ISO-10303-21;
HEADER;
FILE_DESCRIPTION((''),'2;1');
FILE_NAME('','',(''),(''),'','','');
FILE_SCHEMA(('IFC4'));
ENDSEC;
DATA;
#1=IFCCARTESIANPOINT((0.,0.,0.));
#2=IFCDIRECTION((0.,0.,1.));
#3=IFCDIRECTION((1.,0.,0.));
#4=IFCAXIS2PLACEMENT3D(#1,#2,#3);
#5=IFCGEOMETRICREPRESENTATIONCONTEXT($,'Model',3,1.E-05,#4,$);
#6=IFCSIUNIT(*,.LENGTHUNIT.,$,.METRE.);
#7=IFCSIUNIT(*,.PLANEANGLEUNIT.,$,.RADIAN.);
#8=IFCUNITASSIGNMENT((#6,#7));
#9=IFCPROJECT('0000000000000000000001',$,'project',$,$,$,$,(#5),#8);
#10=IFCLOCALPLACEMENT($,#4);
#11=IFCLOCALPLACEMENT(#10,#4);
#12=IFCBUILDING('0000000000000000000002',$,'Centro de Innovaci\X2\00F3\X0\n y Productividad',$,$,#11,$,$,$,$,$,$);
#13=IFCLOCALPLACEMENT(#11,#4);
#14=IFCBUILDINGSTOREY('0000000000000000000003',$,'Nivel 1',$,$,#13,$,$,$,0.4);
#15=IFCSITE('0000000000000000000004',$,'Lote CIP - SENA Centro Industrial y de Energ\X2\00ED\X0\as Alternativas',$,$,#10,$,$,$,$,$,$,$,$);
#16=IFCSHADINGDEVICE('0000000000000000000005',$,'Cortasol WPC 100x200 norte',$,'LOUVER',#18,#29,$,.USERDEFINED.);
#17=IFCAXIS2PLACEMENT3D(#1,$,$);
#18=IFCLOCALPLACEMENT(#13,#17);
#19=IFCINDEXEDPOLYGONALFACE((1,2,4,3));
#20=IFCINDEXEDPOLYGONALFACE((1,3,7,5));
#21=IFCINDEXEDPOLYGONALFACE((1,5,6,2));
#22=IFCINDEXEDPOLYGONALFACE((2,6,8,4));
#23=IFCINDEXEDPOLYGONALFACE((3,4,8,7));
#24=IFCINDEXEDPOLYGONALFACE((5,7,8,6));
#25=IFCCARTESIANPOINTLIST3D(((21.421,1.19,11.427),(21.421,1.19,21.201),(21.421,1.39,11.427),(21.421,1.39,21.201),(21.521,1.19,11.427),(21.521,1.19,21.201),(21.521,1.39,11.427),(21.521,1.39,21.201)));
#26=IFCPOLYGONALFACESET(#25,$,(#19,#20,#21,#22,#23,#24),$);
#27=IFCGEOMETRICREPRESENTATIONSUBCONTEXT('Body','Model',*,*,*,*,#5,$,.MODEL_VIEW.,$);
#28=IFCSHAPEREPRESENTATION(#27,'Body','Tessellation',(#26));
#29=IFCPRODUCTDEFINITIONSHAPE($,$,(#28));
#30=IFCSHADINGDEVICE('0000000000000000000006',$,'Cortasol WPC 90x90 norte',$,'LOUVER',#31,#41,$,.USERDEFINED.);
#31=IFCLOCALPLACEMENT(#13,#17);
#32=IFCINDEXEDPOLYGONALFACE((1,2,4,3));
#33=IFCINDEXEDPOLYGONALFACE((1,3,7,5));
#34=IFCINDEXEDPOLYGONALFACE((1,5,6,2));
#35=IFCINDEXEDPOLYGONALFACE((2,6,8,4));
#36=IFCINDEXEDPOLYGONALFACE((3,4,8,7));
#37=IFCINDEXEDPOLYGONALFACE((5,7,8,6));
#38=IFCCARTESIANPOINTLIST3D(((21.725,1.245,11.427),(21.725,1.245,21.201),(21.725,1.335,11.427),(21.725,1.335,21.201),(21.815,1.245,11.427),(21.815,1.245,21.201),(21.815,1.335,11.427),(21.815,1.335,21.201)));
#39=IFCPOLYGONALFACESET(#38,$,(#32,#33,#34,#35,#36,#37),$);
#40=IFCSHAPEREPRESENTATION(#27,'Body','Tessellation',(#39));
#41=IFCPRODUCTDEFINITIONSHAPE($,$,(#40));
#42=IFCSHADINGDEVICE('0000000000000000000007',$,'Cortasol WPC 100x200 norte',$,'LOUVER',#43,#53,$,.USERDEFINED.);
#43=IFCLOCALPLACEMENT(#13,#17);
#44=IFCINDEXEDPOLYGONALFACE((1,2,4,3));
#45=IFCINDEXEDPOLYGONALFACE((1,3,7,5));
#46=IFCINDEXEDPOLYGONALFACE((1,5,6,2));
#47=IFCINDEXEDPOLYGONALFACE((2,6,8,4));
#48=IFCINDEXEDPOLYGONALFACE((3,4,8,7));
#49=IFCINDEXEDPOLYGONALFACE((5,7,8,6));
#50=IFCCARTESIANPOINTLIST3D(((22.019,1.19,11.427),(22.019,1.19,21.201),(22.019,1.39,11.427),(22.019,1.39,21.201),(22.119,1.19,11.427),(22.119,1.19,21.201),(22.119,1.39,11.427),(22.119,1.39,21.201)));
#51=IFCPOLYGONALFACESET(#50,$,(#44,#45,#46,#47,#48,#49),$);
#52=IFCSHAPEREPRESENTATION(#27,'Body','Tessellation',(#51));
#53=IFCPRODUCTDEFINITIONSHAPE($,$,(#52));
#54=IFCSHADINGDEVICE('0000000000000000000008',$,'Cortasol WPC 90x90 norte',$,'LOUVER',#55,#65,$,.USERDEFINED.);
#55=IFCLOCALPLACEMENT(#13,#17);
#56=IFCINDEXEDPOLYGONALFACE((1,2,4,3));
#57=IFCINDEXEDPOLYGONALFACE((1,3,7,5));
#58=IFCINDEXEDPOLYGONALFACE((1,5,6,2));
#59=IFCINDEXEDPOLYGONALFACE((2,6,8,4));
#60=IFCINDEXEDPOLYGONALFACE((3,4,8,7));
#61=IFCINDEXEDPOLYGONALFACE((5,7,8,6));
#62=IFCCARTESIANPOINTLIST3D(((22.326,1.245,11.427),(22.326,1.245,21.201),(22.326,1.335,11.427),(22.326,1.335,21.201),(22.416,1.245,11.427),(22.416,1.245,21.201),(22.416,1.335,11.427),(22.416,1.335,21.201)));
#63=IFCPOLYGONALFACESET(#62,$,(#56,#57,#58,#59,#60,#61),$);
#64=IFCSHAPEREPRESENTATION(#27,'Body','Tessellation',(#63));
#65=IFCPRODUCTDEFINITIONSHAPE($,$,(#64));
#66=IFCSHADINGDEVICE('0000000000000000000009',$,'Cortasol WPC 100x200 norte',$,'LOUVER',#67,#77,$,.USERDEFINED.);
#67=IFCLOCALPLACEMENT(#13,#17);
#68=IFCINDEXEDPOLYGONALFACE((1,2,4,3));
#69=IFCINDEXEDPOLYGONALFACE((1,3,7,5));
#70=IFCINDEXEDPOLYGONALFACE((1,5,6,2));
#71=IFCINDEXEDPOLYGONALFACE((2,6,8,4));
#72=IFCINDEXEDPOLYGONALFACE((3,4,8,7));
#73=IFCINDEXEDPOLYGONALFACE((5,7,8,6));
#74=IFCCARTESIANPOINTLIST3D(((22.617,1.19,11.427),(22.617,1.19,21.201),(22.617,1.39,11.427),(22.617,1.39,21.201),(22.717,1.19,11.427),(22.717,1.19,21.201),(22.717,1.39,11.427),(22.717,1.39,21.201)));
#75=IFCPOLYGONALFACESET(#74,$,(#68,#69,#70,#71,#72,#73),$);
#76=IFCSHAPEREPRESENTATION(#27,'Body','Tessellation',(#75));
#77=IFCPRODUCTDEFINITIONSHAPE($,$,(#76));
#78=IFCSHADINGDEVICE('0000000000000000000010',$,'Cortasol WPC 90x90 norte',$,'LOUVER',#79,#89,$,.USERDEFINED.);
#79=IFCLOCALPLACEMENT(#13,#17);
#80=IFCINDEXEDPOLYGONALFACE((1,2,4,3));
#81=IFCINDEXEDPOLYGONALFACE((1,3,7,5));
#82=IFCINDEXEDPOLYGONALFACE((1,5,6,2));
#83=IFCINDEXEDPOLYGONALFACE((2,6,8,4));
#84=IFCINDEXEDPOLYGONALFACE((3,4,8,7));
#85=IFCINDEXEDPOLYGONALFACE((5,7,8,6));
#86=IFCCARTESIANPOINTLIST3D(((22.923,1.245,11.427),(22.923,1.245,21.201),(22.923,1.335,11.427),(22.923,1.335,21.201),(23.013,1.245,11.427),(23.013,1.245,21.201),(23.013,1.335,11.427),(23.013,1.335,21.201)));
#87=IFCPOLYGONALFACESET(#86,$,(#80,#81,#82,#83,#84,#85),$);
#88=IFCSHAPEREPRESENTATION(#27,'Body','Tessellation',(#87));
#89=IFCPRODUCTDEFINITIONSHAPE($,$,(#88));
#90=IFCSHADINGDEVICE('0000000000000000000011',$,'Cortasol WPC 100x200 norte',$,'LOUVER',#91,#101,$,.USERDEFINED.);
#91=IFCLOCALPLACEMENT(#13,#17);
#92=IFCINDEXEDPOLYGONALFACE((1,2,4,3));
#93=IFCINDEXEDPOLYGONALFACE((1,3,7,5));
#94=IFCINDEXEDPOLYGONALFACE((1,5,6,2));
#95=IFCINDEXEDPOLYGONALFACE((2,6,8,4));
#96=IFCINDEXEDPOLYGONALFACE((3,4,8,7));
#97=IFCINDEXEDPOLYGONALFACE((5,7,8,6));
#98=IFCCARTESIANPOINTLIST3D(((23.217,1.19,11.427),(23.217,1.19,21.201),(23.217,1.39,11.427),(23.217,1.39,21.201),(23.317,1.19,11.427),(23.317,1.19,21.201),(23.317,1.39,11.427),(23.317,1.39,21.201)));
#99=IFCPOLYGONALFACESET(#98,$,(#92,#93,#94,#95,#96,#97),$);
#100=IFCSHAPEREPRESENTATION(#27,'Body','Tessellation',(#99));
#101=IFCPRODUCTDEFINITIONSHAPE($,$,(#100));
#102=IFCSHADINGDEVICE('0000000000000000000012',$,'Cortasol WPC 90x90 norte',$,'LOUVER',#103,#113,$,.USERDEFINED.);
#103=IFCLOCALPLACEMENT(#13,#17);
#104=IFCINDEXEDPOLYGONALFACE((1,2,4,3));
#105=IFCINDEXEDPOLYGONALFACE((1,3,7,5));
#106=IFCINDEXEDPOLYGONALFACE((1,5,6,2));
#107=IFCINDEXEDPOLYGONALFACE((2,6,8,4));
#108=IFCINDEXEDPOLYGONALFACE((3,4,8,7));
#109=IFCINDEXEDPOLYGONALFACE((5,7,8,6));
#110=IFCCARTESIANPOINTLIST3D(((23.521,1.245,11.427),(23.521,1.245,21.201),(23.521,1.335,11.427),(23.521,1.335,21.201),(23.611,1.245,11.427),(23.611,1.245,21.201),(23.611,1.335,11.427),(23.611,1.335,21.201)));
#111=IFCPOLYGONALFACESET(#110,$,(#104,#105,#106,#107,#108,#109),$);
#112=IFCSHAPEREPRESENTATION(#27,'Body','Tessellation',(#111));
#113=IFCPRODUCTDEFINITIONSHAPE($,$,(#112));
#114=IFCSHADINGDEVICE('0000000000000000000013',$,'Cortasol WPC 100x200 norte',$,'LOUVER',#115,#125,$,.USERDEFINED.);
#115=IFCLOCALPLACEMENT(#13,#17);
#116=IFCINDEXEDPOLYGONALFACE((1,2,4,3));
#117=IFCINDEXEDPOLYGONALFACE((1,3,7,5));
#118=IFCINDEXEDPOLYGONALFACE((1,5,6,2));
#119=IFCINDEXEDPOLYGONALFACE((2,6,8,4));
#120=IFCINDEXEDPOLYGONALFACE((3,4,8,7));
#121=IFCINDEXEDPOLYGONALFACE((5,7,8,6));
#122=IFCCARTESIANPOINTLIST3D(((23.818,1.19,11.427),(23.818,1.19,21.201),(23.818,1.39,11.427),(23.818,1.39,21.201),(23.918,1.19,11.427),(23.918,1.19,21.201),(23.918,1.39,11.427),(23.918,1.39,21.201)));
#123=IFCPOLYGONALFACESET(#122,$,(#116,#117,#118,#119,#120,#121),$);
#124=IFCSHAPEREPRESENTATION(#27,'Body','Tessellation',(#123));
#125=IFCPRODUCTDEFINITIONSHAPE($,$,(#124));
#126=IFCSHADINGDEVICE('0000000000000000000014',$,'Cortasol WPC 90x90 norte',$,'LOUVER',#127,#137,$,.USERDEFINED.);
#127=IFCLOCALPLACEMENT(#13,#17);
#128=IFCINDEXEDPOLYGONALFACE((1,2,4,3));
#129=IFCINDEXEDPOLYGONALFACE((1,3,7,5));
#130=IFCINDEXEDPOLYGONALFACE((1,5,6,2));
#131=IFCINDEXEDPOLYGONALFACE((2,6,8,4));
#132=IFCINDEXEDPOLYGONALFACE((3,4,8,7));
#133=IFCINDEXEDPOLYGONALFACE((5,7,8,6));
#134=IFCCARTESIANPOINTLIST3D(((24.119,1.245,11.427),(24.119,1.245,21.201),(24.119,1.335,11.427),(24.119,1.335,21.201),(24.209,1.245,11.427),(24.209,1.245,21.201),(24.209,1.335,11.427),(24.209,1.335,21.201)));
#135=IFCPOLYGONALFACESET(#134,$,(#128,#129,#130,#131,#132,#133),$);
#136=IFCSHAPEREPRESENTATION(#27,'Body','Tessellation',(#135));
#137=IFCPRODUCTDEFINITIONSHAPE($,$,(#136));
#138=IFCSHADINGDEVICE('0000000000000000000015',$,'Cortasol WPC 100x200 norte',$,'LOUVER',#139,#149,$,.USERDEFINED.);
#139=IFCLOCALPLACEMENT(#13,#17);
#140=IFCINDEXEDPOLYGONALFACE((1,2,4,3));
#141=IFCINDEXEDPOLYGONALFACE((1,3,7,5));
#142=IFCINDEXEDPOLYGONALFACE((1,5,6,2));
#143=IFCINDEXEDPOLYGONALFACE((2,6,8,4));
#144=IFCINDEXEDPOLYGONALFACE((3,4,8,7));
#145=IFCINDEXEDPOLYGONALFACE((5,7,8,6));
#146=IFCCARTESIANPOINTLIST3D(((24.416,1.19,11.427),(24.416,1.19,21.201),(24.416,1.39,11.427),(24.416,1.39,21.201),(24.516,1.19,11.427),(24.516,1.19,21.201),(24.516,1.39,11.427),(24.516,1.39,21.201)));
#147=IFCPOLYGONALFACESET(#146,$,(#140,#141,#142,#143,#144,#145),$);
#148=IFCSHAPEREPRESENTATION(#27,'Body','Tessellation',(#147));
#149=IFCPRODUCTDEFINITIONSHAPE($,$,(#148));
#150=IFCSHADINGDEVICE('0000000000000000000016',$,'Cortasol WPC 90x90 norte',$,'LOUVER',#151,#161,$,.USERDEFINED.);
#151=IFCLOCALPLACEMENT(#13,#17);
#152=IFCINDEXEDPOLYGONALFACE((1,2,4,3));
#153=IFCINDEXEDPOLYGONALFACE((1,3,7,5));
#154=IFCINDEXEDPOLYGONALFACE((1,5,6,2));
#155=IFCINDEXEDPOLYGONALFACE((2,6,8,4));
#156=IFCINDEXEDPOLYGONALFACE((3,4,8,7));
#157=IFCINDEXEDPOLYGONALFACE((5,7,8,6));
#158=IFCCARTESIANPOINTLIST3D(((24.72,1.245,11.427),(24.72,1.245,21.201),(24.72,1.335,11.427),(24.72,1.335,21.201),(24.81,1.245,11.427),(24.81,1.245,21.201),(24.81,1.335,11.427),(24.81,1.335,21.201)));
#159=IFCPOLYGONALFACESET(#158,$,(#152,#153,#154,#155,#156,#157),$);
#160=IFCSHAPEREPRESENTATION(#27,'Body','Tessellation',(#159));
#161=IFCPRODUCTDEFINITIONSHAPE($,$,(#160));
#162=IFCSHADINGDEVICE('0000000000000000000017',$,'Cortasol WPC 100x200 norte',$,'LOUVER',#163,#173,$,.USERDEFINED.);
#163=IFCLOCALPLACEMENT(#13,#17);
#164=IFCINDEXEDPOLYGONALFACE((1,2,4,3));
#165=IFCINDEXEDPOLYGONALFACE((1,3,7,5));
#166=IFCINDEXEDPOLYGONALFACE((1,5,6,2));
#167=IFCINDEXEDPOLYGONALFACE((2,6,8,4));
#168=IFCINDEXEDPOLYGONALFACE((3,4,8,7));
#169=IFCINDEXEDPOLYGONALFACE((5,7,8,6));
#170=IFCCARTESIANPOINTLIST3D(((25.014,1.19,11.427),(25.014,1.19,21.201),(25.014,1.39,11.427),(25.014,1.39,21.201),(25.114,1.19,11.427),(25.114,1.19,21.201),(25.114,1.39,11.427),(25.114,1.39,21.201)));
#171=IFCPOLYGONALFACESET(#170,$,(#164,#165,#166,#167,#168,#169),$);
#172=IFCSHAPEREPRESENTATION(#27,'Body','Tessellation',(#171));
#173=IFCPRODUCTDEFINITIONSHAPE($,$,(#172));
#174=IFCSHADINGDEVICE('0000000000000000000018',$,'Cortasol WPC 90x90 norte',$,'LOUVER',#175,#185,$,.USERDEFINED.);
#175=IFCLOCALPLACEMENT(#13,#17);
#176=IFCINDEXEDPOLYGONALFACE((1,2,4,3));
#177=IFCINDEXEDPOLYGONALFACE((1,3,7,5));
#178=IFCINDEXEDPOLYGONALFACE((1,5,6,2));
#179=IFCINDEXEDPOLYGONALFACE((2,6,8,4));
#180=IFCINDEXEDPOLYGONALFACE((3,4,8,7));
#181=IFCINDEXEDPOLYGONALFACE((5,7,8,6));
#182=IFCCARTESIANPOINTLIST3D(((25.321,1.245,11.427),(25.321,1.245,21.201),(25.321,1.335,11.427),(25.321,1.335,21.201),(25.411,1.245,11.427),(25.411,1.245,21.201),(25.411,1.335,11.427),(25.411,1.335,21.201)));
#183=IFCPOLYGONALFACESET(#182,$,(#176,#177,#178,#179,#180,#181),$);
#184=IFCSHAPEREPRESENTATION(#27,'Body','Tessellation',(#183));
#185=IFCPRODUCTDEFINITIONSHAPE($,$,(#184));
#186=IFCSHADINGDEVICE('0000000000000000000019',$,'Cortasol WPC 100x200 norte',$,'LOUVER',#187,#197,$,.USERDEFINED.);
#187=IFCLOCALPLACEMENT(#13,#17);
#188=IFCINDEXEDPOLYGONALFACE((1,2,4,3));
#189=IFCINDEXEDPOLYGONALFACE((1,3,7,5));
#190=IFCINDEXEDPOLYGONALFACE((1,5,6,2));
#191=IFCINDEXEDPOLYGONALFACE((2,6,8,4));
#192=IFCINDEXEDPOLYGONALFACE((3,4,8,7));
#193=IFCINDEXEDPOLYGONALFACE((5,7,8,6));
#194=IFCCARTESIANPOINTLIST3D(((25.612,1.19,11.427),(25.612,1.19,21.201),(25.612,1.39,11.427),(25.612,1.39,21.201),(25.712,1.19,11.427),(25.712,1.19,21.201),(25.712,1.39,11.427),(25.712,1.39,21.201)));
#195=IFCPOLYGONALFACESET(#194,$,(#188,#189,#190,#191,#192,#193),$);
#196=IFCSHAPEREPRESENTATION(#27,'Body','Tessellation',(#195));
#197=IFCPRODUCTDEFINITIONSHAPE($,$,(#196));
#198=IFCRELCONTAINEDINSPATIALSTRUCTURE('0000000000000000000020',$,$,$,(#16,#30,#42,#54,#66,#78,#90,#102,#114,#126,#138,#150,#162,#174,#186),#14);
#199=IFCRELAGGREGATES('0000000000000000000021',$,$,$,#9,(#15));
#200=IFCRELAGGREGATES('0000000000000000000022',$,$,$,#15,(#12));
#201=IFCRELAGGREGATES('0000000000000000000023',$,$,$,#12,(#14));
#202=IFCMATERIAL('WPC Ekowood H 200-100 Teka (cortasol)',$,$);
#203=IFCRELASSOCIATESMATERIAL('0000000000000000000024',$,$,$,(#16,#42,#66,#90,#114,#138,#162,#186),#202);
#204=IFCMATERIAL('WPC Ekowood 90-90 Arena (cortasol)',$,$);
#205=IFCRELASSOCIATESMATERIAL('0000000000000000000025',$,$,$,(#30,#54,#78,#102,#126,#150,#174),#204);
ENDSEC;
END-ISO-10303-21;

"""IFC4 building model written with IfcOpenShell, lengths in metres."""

from ifc_helpers import new_model, si_unit, frame, origin_with_axes, place, context, subcontext, project, spatial, polyline, outline, extrude, material, element, save


model = new_model("IFC4")

# Units and contexts
model_context = context("Model", 3, precision=1e-05, world=origin_with_axes())
body_context = subcontext(model_context, "Body", "Model", "MODEL_VIEW")
ifc_project = project(units=[si_unit("LENGTHUNIT", "METRE"), si_unit("PLANEANGLEUNIT", "RADIAN")], contexts=[model_context])

# Site, building, storey
site_placement = place(None, origin_with_axes())
site = spatial("IfcSite", under=ifc_project, at=site_placement, Name="Lote CIP - SENA Centro Industrial y de Energías Alternativas")
building_placement = place(site_placement, origin_with_axes())
building = spatial("IfcBuilding", under=site, at=building_placement, Name="Centro de Innovación y Productividad")
storey_placement = place(building_placement, origin_with_axes())
storey = spatial("IfcBuildingStorey", under=building, at=storey_placement, Name="Nivel 1", Elevation=0.4)

# Shading devices
ifc_material_1 = material(Name="WPC Ekowood H 200-100 Teka (cortasol)")
shading_device_1_placement = place(storey_placement, origin_with_axes())
element("IfcShadingDevice", 1, at=shading_device_1_placement, inside=storey, material=ifc_material_1, Name="Cortasol WPC 100x200 norte", ObjectType="LOUVER", PredefinedType="USERDEFINED", context=body_context, shape_type="SweptSolid", body=[
    extrude(outline(polyline([(21.421, 1.19), (21.421, 1.39), (21.521, 1.39), (21.521, 1.19), (21.421, 1.19)])), frame((0.0, 0.0, 11.427)), (0.0, 0.0, 1.0), 9.774),
])
ifc_material_2 = material(Name="WPC Ekowood 90-90 Arena (cortasol)")
shading_device_2_placement = place(storey_placement, origin_with_axes())
element("IfcShadingDevice", 2, at=shading_device_2_placement, inside=storey, material=ifc_material_2, Name="Cortasol WPC 90x90 norte", ObjectType="LOUVER", PredefinedType="USERDEFINED", context=body_context, shape_type="SweptSolid", body=[
    extrude(outline(polyline([(21.725, 1.245), (21.725, 1.335), (21.815, 1.335), (21.815, 1.245), (21.725, 1.245)])), frame((0.0, 0.0, 11.427)), (0.0, 0.0, 1.0), 9.774),
])
shading_device_3_placement = place(storey_placement, origin_with_axes())
element("IfcShadingDevice", 3, at=shading_device_3_placement, inside=storey, material=ifc_material_1, Name="Cortasol WPC 100x200 norte", ObjectType="LOUVER", PredefinedType="USERDEFINED", context=body_context, shape_type="SweptSolid", body=[
    extrude(outline(polyline([(22.019, 1.19), (22.019, 1.39), (22.119, 1.39), (22.119, 1.19), (22.019, 1.19)])), frame((0.0, 0.0, 11.427)), (0.0, 0.0, 1.0), 9.774),
])
shading_device_4_placement = place(storey_placement, origin_with_axes())
element("IfcShadingDevice", 4, at=shading_device_4_placement, inside=storey, material=ifc_material_2, Name="Cortasol WPC 90x90 norte", ObjectType="LOUVER", PredefinedType="USERDEFINED", context=body_context, shape_type="SweptSolid", body=[
    extrude(outline(polyline([(22.326, 1.245), (22.326, 1.335), (22.416, 1.335), (22.416, 1.245), (22.326, 1.245)])), frame((0.0, 0.0, 11.427)), (0.0, 0.0, 1.0), 9.774),
])
shading_device_5_placement = place(storey_placement, origin_with_axes())
element("IfcShadingDevice", 5, at=shading_device_5_placement, inside=storey, material=ifc_material_1, Name="Cortasol WPC 100x200 norte", ObjectType="LOUVER", PredefinedType="USERDEFINED", context=body_context, shape_type="SweptSolid", body=[
    extrude(outline(polyline([(22.617, 1.19), (22.617, 1.39), (22.717, 1.39), (22.717, 1.19), (22.617, 1.19)])), frame((0.0, 0.0, 11.427)), (0.0, 0.0, 1.0), 9.774),
])
shading_device_6_placement = place(storey_placement, origin_with_axes())
element("IfcShadingDevice", 6, at=shading_device_6_placement, inside=storey, material=ifc_material_2, Name="Cortasol WPC 90x90 norte", ObjectType="LOUVER", PredefinedType="USERDEFINED", context=body_context, shape_type="SweptSolid", body=[
    extrude(outline(polyline([(22.923, 1.245), (22.923, 1.335), (23.013, 1.335), (23.013, 1.245), (22.923, 1.245)])), frame((0.0, 0.0, 11.427)), (0.0, 0.0, 1.0), 9.774),
])
shading_device_7_placement = place(storey_placement, origin_with_axes())
element("IfcShadingDevice", 7, at=shading_device_7_placement, inside=storey, material=ifc_material_1, Name="Cortasol WPC 100x200 norte", ObjectType="LOUVER", PredefinedType="USERDEFINED", context=body_context, shape_type="SweptSolid", body=[
    extrude(outline(polyline([(23.217, 1.19), (23.217, 1.39), (23.317, 1.39), (23.317, 1.19), (23.217, 1.19)])), frame((0.0, 0.0, 11.427)), (0.0, 0.0, 1.0), 9.774),
])
shading_device_8_placement = place(storey_placement, origin_with_axes())
element("IfcShadingDevice", 8, at=shading_device_8_placement, inside=storey, material=ifc_material_2, Name="Cortasol WPC 90x90 norte", ObjectType="LOUVER", PredefinedType="USERDEFINED", context=body_context, shape_type="SweptSolid", body=[
    extrude(outline(polyline([(23.521, 1.245), (23.521, 1.335), (23.611, 1.335), (23.611, 1.245), (23.521, 1.245)])), frame((0.0, 0.0, 11.427)), (0.0, 0.0, 1.0), 9.774),
])
shading_device_9_placement = place(storey_placement, origin_with_axes())
element("IfcShadingDevice", 9, at=shading_device_9_placement, inside=storey, material=ifc_material_1, Name="Cortasol WPC 100x200 norte", ObjectType="LOUVER", PredefinedType="USERDEFINED", context=body_context, shape_type="SweptSolid", body=[
    extrude(outline(polyline([(23.818, 1.19), (23.818, 1.39), (23.918, 1.39), (23.918, 1.19), (23.818, 1.19)])), frame((0.0, 0.0, 11.427)), (0.0, 0.0, 1.0), 9.774),
])
shading_device_10_placement = place(storey_placement, origin_with_axes())
element("IfcShadingDevice", 10, at=shading_device_10_placement, inside=storey, material=ifc_material_2, Name="Cortasol WPC 90x90 norte", ObjectType="LOUVER", PredefinedType="USERDEFINED", context=body_context, shape_type="SweptSolid", body=[
    extrude(outline(polyline([(24.119, 1.245), (24.119, 1.335), (24.209, 1.335), (24.209, 1.245), (24.119, 1.245)])), frame((0.0, 0.0, 11.427)), (0.0, 0.0, 1.0), 9.774),
])
shading_device_11_placement = place(storey_placement, origin_with_axes())
element("IfcShadingDevice", 11, at=shading_device_11_placement, inside=storey, material=ifc_material_1, Name="Cortasol WPC 100x200 norte", ObjectType="LOUVER", PredefinedType="USERDEFINED", context=body_context, shape_type="SweptSolid", body=[
    extrude(outline(polyline([(24.416, 1.19), (24.416, 1.39), (24.516, 1.39), (24.516, 1.19), (24.416, 1.19)])), frame((0.0, 0.0, 11.427)), (0.0, 0.0, 1.0), 9.774),
])
shading_device_12_placement = place(storey_placement, origin_with_axes())
element("IfcShadingDevice", 12, at=shading_device_12_placement, inside=storey, material=ifc_material_2, Name="Cortasol WPC 90x90 norte", ObjectType="LOUVER", PredefinedType="USERDEFINED", context=body_context, shape_type="SweptSolid", body=[
    extrude(outline(polyline([(24.72, 1.245), (24.72, 1.335), (24.81, 1.335), (24.81, 1.245), (24.72, 1.245)])), frame((0.0, 0.0, 11.427)), (0.0, 0.0, 1.0), 9.774),
])
shading_device_13_placement = place(storey_placement, origin_with_axes())
element("IfcShadingDevice", 13, at=shading_device_13_placement, inside=storey, material=ifc_material_1, Name="Cortasol WPC 100x200 norte", ObjectType="LOUVER", PredefinedType="USERDEFINED", context=body_context, shape_type="SweptSolid", body=[
    extrude(outline(polyline([(25.014, 1.19), (25.014, 1.39), (25.114, 1.39), (25.114, 1.19), (25.014, 1.19)])), frame((0.0, 0.0, 11.427)), (0.0, 0.0, 1.0), 9.774),
])
shading_device_14_placement = place(storey_placement, origin_with_axes())
element("IfcShadingDevice", 14, at=shading_device_14_placement, inside=storey, material=ifc_material_2, Name="Cortasol WPC 90x90 norte", ObjectType="LOUVER", PredefinedType="USERDEFINED", context=body_context, shape_type="SweptSolid", body=[
    extrude(outline(polyline([(25.321, 1.245), (25.321, 1.335), (25.411, 1.335), (25.411, 1.245), (25.321, 1.245)])), frame((0.0, 0.0, 11.427)), (0.0, 0.0, 1.0), 9.774),
])
shading_device_15_placement = place(storey_placement, origin_with_axes())
element("IfcShadingDevice", 15, at=shading_device_15_placement, inside=storey, material=ifc_material_1, Name="Cortasol WPC 100x200 norte", ObjectType="LOUVER", PredefinedType="USERDEFINED", context=body_context, shape_type="SweptSolid", body=[
    extrude(outline(polyline([(25.612, 1.19), (25.612, 1.39), (25.712, 1.39), (25.712, 1.19), (25.612, 1.19)])), frame((0.0, 0.0, 11.427)), (0.0, 0.0, 1.0), 9.774),
])

save(model, "model.ifc")
